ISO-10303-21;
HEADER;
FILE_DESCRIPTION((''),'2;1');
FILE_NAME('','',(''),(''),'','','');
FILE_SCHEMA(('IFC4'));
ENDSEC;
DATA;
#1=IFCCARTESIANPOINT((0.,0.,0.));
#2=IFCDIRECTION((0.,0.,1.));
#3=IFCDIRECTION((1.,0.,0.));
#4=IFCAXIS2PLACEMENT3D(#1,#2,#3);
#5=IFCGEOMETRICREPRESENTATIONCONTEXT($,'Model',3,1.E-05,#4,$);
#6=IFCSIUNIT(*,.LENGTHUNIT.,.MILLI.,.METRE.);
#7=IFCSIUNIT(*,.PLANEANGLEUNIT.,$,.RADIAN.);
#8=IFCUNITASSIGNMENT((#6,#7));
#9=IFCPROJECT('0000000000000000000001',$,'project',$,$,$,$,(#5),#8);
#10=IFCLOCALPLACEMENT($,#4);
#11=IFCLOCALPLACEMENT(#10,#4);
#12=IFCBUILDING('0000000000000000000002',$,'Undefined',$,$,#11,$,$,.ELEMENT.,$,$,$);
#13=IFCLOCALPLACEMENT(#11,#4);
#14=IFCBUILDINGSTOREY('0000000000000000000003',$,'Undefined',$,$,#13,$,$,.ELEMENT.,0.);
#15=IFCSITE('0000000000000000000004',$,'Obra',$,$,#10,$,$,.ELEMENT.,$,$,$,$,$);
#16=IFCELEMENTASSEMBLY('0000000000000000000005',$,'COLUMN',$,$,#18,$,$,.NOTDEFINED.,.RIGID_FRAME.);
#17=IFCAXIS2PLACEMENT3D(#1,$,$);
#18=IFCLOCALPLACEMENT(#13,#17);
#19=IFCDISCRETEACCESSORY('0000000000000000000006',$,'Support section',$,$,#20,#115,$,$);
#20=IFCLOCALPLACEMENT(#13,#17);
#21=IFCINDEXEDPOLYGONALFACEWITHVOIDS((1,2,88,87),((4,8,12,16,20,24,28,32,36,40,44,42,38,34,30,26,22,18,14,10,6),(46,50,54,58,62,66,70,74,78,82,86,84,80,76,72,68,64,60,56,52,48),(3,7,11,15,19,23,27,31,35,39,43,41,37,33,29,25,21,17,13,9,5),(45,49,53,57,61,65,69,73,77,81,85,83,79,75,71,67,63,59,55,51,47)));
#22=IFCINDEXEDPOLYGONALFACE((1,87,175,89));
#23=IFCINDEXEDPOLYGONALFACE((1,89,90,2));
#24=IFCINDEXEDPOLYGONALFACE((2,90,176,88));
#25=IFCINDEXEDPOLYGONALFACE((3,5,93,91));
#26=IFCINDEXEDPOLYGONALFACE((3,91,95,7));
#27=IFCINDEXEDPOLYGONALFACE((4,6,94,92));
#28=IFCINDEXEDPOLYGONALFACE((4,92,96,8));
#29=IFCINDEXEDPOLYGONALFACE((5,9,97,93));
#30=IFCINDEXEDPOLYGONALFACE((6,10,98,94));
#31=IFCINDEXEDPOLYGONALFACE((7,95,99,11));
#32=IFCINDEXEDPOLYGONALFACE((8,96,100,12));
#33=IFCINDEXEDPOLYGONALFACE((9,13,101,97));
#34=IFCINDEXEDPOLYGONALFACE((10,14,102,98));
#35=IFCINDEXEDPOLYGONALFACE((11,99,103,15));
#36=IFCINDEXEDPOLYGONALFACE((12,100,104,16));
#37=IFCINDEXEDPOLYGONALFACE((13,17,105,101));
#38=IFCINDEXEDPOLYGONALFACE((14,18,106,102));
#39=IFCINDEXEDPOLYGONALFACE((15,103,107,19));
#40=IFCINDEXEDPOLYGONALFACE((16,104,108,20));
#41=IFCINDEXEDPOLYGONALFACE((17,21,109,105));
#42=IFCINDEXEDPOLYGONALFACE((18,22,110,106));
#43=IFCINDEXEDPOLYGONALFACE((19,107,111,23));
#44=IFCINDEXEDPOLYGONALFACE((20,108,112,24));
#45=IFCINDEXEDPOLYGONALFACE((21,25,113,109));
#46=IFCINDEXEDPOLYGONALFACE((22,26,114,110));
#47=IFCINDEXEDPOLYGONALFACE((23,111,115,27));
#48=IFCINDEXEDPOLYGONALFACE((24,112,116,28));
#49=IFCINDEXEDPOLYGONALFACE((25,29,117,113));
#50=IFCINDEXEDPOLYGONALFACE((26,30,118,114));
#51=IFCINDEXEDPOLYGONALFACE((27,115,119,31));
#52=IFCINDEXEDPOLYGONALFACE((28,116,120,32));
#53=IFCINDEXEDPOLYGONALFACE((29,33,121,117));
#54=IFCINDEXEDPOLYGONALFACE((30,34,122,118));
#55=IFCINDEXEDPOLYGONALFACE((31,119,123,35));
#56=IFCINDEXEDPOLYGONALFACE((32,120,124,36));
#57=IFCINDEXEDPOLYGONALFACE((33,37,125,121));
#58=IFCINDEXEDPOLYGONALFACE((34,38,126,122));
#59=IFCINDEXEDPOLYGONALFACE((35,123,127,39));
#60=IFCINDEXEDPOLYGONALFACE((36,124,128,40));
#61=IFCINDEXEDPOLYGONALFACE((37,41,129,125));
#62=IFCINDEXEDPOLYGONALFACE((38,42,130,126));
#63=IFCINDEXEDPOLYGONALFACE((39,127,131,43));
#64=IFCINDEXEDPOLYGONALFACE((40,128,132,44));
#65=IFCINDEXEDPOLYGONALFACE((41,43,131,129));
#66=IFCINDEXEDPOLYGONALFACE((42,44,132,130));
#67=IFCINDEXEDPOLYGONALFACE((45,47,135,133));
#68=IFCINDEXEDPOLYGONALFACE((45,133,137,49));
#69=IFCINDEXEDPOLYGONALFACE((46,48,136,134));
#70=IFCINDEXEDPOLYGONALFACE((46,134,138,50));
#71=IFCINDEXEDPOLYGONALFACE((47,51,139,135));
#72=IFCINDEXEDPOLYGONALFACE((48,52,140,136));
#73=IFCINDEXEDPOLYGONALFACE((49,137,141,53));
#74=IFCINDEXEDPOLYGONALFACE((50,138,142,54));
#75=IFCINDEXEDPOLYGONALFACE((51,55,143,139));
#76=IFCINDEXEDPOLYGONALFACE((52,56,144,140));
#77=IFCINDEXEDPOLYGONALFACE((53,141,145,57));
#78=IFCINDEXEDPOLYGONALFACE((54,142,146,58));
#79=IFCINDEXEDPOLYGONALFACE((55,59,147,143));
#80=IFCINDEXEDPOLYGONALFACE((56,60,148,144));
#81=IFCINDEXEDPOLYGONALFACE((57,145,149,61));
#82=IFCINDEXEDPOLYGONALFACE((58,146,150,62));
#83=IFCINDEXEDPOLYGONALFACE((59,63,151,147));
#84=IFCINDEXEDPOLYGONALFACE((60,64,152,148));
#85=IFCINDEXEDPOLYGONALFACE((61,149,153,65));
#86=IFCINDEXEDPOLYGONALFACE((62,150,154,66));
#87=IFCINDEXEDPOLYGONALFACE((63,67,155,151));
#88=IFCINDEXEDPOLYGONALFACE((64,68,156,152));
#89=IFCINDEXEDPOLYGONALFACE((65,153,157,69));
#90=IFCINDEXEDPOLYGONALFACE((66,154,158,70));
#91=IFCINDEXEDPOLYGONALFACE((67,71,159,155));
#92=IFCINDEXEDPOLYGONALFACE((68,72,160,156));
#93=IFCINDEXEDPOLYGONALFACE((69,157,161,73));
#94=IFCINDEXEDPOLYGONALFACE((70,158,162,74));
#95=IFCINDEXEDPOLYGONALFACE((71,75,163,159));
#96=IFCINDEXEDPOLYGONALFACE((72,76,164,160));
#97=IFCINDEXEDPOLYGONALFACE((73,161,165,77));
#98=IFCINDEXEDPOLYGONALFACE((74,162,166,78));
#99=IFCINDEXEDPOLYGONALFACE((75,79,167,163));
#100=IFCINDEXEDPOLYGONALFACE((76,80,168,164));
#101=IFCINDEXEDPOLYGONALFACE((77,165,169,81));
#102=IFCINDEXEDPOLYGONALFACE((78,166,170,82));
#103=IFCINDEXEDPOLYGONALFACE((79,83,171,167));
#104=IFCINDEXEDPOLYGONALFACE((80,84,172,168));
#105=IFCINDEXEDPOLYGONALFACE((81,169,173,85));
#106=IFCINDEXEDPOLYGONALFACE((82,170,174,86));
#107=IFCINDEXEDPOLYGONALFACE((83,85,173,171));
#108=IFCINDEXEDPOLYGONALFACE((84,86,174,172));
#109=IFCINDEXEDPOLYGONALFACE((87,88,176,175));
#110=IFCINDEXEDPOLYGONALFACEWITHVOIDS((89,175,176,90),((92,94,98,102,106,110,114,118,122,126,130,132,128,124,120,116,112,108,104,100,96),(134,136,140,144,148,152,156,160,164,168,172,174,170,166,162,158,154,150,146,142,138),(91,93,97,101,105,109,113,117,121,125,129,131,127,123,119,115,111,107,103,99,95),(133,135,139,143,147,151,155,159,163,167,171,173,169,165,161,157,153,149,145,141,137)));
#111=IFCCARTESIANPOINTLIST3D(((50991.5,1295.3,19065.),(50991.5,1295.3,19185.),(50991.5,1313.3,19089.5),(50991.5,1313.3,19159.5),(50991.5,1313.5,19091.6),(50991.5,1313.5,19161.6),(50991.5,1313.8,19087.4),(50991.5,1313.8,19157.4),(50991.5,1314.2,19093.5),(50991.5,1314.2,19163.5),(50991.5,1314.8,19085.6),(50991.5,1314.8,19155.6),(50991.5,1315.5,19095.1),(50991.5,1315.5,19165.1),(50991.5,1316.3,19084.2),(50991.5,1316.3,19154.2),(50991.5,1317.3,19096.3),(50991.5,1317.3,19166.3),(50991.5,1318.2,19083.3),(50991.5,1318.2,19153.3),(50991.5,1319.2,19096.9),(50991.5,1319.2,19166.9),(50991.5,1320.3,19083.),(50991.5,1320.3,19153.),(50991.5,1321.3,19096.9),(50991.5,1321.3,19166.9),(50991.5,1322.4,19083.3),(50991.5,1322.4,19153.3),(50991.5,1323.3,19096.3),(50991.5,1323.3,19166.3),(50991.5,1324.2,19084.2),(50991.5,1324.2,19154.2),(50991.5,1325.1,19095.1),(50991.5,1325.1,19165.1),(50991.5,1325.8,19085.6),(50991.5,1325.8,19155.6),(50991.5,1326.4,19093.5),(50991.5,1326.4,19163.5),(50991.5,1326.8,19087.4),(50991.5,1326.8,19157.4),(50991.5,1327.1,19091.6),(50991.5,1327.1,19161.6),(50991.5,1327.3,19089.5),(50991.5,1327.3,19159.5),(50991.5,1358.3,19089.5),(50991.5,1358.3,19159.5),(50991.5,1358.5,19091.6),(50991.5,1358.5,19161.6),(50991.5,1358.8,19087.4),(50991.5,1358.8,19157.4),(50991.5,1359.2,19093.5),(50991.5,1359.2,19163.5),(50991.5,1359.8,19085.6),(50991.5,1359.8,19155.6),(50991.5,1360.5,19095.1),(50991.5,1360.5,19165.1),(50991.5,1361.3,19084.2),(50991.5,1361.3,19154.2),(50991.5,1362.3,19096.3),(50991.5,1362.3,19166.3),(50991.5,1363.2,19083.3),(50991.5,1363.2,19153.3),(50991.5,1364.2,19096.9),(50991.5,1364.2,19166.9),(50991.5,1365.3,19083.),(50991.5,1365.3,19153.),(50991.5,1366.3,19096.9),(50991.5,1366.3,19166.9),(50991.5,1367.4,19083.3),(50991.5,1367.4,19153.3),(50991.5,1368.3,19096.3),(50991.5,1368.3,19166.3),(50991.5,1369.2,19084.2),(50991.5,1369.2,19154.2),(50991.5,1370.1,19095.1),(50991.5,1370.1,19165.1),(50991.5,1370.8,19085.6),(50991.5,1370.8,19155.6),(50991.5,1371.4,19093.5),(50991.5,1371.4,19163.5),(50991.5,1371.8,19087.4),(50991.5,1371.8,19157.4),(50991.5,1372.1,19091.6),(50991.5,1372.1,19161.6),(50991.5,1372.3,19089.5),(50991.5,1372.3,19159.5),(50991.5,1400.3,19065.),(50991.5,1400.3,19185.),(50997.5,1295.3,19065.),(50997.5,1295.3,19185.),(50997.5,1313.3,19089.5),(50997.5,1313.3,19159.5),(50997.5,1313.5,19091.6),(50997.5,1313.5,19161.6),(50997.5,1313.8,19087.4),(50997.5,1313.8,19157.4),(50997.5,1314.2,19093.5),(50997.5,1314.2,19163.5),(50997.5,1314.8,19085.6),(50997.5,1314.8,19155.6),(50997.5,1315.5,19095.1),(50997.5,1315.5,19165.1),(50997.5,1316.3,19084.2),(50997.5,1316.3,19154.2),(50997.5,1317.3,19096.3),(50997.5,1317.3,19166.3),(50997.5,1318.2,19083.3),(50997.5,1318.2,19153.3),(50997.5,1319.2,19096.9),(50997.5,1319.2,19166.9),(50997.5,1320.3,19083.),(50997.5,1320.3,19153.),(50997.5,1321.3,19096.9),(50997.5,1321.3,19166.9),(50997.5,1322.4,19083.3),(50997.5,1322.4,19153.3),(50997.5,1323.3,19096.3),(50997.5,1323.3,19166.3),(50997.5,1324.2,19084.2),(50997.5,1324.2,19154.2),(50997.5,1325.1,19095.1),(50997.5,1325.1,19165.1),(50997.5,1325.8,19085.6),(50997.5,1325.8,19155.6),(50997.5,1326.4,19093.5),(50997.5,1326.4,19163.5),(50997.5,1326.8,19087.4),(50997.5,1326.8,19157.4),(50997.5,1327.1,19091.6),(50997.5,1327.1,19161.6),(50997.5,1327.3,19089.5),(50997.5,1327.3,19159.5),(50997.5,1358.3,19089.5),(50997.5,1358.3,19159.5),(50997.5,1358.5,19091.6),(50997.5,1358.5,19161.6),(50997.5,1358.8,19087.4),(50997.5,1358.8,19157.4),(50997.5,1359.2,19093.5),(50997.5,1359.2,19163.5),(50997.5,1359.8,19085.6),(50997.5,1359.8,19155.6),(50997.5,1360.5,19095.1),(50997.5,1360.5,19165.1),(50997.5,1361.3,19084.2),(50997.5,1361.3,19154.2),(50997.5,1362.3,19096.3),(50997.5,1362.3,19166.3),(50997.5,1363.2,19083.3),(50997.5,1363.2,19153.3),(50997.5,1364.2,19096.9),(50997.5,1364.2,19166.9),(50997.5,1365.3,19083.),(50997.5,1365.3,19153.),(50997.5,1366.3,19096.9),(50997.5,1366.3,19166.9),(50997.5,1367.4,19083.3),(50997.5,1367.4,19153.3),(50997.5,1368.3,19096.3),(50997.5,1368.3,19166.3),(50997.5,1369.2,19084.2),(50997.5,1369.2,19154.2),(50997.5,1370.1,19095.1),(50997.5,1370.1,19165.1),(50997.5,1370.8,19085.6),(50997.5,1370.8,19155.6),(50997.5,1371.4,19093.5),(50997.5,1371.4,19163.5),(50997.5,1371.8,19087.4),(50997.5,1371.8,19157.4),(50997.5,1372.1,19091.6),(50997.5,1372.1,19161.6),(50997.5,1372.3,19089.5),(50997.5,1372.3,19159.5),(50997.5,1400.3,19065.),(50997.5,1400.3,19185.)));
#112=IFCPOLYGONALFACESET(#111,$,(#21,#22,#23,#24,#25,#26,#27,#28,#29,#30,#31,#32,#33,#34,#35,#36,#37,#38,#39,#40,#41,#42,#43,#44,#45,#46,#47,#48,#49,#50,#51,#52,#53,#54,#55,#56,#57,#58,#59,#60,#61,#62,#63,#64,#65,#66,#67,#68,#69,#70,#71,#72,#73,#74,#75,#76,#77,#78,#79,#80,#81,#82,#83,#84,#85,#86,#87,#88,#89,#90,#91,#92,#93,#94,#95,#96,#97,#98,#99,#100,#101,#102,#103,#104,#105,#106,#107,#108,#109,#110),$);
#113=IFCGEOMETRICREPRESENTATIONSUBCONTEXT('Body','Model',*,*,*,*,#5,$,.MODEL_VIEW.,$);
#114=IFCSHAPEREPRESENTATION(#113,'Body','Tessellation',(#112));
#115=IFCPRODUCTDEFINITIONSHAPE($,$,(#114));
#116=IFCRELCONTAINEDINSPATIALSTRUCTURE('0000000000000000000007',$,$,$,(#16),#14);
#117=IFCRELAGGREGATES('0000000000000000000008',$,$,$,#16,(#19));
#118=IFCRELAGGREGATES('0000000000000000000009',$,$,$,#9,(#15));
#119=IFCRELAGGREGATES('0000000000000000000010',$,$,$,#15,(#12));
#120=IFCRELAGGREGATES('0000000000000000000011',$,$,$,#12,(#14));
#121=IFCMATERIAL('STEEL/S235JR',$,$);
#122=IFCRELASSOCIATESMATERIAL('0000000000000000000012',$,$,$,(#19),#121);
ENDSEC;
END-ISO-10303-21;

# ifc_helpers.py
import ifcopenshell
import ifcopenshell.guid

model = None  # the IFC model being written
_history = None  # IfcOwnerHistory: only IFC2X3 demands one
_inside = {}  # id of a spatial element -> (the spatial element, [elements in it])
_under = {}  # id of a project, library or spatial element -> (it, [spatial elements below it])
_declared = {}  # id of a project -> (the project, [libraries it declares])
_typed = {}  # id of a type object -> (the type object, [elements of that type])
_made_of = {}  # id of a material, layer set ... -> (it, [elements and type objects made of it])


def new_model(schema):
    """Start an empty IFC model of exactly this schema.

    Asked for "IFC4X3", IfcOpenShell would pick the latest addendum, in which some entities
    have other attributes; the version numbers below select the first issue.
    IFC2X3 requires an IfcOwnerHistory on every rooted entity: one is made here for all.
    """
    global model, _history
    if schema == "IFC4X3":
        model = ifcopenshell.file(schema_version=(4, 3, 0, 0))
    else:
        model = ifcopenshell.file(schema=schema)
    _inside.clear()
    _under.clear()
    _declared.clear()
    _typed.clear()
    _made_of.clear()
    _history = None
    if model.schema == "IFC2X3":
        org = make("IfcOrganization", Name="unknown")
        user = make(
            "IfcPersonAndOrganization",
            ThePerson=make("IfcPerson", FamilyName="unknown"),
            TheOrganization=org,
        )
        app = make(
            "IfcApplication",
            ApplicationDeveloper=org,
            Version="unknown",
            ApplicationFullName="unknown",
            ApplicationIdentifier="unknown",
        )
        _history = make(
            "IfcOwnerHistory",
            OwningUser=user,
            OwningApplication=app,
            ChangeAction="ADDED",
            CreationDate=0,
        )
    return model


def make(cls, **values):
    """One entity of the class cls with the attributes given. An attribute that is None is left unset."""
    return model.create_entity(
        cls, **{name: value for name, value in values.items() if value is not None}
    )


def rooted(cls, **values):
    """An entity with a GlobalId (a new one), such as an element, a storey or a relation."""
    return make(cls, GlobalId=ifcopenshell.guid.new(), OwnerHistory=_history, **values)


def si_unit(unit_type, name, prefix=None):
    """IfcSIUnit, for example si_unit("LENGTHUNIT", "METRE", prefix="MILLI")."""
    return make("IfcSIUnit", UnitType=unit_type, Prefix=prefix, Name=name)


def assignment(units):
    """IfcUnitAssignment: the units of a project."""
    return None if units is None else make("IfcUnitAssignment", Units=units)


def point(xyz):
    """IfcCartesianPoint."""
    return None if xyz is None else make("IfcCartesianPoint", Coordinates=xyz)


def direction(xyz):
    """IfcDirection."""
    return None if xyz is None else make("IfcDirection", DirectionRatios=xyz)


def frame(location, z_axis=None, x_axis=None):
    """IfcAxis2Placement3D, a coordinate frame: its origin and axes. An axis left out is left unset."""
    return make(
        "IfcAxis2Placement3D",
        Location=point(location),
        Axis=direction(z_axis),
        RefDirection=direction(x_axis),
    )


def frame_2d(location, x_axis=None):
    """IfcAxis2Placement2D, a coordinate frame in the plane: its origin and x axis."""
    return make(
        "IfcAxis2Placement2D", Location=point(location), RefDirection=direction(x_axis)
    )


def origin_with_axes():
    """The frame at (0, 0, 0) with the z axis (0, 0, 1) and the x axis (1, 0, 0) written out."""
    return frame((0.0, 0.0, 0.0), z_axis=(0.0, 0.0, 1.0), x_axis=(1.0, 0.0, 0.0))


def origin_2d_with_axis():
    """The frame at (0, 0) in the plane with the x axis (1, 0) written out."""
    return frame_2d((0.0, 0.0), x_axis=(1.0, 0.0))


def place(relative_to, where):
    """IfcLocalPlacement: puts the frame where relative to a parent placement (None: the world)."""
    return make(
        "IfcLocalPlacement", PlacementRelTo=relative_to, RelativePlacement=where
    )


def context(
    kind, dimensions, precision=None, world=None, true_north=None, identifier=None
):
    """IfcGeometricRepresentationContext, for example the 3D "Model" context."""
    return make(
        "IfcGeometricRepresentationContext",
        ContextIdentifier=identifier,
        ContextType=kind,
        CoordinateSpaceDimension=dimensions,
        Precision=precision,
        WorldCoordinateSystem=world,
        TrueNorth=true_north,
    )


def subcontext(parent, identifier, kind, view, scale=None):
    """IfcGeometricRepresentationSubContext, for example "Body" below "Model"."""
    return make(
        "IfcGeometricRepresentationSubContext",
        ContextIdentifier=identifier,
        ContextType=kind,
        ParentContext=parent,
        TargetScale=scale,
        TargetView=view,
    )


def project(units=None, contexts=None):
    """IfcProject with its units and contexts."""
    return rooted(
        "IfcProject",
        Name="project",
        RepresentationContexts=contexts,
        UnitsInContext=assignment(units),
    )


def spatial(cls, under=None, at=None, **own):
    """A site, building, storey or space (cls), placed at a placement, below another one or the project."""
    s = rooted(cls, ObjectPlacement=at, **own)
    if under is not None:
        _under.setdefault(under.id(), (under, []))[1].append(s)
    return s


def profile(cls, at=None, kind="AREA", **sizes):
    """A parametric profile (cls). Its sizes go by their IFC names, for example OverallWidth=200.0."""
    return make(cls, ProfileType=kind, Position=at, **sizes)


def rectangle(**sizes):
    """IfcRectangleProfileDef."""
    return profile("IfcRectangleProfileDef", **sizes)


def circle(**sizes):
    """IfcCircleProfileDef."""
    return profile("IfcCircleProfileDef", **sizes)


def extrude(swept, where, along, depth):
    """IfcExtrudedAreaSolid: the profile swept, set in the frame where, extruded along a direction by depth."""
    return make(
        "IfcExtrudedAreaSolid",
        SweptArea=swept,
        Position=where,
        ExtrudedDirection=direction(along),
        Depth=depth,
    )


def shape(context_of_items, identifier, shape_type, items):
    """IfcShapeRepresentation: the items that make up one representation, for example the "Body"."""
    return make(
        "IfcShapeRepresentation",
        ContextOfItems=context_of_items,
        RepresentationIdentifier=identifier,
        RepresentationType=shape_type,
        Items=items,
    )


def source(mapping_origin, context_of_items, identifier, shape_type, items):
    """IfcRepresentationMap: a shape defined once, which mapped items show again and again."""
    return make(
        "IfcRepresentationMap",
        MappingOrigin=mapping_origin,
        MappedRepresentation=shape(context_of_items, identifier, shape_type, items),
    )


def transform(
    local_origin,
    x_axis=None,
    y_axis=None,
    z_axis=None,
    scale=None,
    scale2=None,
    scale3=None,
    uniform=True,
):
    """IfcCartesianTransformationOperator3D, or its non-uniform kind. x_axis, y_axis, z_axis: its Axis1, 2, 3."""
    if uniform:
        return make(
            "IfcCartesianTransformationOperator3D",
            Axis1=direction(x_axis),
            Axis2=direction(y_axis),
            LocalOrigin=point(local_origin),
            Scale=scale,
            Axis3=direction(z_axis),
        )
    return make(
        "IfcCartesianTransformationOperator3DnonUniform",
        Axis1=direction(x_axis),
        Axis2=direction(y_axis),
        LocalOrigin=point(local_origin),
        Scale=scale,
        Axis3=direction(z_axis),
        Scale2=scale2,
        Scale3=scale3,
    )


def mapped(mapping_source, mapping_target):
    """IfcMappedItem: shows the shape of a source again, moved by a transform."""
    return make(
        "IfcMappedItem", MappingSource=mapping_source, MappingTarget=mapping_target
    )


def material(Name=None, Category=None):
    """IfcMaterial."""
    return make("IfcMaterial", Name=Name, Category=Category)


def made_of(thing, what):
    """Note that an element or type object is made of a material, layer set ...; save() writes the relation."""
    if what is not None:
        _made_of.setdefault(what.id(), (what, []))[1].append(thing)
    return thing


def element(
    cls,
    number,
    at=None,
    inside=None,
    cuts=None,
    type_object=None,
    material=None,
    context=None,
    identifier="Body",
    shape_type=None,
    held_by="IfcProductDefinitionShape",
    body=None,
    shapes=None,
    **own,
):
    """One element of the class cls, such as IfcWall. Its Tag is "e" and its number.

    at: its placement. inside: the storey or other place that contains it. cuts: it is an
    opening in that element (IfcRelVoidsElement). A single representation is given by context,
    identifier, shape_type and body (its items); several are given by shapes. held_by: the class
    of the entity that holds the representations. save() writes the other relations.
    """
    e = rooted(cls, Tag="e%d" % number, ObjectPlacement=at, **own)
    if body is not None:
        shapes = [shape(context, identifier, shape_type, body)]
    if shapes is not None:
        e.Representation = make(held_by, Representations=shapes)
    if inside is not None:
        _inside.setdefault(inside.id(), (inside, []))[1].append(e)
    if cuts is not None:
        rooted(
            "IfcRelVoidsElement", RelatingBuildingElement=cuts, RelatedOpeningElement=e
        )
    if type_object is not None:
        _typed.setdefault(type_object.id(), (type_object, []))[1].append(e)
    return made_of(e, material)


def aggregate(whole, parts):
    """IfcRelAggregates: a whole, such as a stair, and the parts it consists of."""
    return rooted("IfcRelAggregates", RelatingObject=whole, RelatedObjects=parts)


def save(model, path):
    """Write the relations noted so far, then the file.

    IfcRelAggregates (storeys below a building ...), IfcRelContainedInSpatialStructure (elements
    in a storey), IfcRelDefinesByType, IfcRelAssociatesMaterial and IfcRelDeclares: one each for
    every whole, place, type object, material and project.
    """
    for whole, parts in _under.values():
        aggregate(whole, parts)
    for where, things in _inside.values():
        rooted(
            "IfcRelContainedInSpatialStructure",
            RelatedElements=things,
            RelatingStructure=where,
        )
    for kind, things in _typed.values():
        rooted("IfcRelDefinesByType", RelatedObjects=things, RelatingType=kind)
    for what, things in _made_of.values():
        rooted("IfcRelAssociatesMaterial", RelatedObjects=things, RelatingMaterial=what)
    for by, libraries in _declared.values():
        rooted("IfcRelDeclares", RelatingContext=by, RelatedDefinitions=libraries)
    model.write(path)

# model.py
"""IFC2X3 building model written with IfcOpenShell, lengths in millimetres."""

from ifc_helpers import new_model, si_unit, frame, origin_with_axes, origin_2d_with_axis, place, context, subcontext, project, spatial, rectangle, circle, extrude, source, transform, mapped, material, element, aggregate, save


model = new_model("IFC2X3")

# Units and contexts
model_context = context("Model", 3, precision=1e-05, world=origin_with_axes())
body_context = subcontext(model_context, "Body", "Model", "MODEL_VIEW")
ifc_project = project(units=[si_unit("LENGTHUNIT", "METRE", prefix="MILLI"), si_unit("PLANEANGLEUNIT", "RADIAN")], contexts=[model_context])

# Site, building, storey
site_placement = place(None, origin_with_axes())
site = spatial("IfcSite", under=ifc_project, at=site_placement, Name="Obra", CompositionType="ELEMENT")
building_placement = place(site_placement, origin_with_axes())
building = spatial("IfcBuilding", under=site, at=building_placement, Name="Undefined", CompositionType="ELEMENT")
storey_placement = place(building_placement, origin_with_axes())
storey = spatial("IfcBuildingStorey", under=building, at=storey_placement, Name="Undefined", CompositionType="ELEMENT", Elevation=0.0)

# Shared definitions
ifc_material_1 = material(Name="STEEL/S235JR")

# Element assembly, discrete accessory, opening
assembly_1_placement = place(storey_placement, origin_with_axes())
assembly_1 = element("IfcElementAssembly", 1, at=assembly_1_placement, inside=storey, Name="COLUMN", AssemblyPlace="NOTDEFINED", PredefinedType="RIGID_FRAME")
shared_shape_1 = source(origin_with_axes(), body_context, "Body", "SweptSolid", [
    extrude(circle(Radius=7.0, at=origin_2d_with_axis()), frame((0.0, -8.6, 0.0), z_axis=(0.0, 1.0, 0.0), x_axis=(1.0, 0.0, 0.0)), (0.0, 0.0, 1.0), 6.2),
])
discrete_accessory_1_placement = place(assembly_1_placement, frame((50994.5, 1347.8, 19065.0), z_axis=(0.0, 0.0, 1.0), x_axis=(0.0, 1.0, 0.0)))
discrete_accessory_1 = element("IfcDiscreteAccessory", 2, at=discrete_accessory_1_placement, material=ifc_material_1, Name="Support section", context=body_context, shape_type="SweptSolid", body=[
    extrude(rectangle(XDim=6.0, YDim=105.0, at=origin_2d_with_axis()), frame((0.0, 0.0, 120.0), z_axis=(0.0, 0.0, -1.0), x_axis=(0.0, 1.0, 0.0)), (0.0, 0.0, 1.0), 120.0),
])
opening_1_placement = place(assembly_1_placement, frame((51000.0, 1390.3, 19205.0), z_axis=(0.0, -1.0, 0.0), x_axis=(0.0, 0.0, -1.0)))
element("IfcOpeningElement", 3, at=opening_1_placement, cuts=discrete_accessory_1, ObjectType="Opening", context=body_context, shape_type="MappedRepresentation", body=[
    mapped(shared_shape_1, transform((45.0, 0.0, 25.0))),
    mapped(shared_shape_1, transform((45.0, 0.0, 70.0))),
    mapped(shared_shape_1, transform((115.0, 0.0, 25.0))),
    mapped(shared_shape_1, transform((115.0, 0.0, 70.0))),
])

aggregate(assembly_1, [discrete_accessory_1])

save(model, "model.ifc")
